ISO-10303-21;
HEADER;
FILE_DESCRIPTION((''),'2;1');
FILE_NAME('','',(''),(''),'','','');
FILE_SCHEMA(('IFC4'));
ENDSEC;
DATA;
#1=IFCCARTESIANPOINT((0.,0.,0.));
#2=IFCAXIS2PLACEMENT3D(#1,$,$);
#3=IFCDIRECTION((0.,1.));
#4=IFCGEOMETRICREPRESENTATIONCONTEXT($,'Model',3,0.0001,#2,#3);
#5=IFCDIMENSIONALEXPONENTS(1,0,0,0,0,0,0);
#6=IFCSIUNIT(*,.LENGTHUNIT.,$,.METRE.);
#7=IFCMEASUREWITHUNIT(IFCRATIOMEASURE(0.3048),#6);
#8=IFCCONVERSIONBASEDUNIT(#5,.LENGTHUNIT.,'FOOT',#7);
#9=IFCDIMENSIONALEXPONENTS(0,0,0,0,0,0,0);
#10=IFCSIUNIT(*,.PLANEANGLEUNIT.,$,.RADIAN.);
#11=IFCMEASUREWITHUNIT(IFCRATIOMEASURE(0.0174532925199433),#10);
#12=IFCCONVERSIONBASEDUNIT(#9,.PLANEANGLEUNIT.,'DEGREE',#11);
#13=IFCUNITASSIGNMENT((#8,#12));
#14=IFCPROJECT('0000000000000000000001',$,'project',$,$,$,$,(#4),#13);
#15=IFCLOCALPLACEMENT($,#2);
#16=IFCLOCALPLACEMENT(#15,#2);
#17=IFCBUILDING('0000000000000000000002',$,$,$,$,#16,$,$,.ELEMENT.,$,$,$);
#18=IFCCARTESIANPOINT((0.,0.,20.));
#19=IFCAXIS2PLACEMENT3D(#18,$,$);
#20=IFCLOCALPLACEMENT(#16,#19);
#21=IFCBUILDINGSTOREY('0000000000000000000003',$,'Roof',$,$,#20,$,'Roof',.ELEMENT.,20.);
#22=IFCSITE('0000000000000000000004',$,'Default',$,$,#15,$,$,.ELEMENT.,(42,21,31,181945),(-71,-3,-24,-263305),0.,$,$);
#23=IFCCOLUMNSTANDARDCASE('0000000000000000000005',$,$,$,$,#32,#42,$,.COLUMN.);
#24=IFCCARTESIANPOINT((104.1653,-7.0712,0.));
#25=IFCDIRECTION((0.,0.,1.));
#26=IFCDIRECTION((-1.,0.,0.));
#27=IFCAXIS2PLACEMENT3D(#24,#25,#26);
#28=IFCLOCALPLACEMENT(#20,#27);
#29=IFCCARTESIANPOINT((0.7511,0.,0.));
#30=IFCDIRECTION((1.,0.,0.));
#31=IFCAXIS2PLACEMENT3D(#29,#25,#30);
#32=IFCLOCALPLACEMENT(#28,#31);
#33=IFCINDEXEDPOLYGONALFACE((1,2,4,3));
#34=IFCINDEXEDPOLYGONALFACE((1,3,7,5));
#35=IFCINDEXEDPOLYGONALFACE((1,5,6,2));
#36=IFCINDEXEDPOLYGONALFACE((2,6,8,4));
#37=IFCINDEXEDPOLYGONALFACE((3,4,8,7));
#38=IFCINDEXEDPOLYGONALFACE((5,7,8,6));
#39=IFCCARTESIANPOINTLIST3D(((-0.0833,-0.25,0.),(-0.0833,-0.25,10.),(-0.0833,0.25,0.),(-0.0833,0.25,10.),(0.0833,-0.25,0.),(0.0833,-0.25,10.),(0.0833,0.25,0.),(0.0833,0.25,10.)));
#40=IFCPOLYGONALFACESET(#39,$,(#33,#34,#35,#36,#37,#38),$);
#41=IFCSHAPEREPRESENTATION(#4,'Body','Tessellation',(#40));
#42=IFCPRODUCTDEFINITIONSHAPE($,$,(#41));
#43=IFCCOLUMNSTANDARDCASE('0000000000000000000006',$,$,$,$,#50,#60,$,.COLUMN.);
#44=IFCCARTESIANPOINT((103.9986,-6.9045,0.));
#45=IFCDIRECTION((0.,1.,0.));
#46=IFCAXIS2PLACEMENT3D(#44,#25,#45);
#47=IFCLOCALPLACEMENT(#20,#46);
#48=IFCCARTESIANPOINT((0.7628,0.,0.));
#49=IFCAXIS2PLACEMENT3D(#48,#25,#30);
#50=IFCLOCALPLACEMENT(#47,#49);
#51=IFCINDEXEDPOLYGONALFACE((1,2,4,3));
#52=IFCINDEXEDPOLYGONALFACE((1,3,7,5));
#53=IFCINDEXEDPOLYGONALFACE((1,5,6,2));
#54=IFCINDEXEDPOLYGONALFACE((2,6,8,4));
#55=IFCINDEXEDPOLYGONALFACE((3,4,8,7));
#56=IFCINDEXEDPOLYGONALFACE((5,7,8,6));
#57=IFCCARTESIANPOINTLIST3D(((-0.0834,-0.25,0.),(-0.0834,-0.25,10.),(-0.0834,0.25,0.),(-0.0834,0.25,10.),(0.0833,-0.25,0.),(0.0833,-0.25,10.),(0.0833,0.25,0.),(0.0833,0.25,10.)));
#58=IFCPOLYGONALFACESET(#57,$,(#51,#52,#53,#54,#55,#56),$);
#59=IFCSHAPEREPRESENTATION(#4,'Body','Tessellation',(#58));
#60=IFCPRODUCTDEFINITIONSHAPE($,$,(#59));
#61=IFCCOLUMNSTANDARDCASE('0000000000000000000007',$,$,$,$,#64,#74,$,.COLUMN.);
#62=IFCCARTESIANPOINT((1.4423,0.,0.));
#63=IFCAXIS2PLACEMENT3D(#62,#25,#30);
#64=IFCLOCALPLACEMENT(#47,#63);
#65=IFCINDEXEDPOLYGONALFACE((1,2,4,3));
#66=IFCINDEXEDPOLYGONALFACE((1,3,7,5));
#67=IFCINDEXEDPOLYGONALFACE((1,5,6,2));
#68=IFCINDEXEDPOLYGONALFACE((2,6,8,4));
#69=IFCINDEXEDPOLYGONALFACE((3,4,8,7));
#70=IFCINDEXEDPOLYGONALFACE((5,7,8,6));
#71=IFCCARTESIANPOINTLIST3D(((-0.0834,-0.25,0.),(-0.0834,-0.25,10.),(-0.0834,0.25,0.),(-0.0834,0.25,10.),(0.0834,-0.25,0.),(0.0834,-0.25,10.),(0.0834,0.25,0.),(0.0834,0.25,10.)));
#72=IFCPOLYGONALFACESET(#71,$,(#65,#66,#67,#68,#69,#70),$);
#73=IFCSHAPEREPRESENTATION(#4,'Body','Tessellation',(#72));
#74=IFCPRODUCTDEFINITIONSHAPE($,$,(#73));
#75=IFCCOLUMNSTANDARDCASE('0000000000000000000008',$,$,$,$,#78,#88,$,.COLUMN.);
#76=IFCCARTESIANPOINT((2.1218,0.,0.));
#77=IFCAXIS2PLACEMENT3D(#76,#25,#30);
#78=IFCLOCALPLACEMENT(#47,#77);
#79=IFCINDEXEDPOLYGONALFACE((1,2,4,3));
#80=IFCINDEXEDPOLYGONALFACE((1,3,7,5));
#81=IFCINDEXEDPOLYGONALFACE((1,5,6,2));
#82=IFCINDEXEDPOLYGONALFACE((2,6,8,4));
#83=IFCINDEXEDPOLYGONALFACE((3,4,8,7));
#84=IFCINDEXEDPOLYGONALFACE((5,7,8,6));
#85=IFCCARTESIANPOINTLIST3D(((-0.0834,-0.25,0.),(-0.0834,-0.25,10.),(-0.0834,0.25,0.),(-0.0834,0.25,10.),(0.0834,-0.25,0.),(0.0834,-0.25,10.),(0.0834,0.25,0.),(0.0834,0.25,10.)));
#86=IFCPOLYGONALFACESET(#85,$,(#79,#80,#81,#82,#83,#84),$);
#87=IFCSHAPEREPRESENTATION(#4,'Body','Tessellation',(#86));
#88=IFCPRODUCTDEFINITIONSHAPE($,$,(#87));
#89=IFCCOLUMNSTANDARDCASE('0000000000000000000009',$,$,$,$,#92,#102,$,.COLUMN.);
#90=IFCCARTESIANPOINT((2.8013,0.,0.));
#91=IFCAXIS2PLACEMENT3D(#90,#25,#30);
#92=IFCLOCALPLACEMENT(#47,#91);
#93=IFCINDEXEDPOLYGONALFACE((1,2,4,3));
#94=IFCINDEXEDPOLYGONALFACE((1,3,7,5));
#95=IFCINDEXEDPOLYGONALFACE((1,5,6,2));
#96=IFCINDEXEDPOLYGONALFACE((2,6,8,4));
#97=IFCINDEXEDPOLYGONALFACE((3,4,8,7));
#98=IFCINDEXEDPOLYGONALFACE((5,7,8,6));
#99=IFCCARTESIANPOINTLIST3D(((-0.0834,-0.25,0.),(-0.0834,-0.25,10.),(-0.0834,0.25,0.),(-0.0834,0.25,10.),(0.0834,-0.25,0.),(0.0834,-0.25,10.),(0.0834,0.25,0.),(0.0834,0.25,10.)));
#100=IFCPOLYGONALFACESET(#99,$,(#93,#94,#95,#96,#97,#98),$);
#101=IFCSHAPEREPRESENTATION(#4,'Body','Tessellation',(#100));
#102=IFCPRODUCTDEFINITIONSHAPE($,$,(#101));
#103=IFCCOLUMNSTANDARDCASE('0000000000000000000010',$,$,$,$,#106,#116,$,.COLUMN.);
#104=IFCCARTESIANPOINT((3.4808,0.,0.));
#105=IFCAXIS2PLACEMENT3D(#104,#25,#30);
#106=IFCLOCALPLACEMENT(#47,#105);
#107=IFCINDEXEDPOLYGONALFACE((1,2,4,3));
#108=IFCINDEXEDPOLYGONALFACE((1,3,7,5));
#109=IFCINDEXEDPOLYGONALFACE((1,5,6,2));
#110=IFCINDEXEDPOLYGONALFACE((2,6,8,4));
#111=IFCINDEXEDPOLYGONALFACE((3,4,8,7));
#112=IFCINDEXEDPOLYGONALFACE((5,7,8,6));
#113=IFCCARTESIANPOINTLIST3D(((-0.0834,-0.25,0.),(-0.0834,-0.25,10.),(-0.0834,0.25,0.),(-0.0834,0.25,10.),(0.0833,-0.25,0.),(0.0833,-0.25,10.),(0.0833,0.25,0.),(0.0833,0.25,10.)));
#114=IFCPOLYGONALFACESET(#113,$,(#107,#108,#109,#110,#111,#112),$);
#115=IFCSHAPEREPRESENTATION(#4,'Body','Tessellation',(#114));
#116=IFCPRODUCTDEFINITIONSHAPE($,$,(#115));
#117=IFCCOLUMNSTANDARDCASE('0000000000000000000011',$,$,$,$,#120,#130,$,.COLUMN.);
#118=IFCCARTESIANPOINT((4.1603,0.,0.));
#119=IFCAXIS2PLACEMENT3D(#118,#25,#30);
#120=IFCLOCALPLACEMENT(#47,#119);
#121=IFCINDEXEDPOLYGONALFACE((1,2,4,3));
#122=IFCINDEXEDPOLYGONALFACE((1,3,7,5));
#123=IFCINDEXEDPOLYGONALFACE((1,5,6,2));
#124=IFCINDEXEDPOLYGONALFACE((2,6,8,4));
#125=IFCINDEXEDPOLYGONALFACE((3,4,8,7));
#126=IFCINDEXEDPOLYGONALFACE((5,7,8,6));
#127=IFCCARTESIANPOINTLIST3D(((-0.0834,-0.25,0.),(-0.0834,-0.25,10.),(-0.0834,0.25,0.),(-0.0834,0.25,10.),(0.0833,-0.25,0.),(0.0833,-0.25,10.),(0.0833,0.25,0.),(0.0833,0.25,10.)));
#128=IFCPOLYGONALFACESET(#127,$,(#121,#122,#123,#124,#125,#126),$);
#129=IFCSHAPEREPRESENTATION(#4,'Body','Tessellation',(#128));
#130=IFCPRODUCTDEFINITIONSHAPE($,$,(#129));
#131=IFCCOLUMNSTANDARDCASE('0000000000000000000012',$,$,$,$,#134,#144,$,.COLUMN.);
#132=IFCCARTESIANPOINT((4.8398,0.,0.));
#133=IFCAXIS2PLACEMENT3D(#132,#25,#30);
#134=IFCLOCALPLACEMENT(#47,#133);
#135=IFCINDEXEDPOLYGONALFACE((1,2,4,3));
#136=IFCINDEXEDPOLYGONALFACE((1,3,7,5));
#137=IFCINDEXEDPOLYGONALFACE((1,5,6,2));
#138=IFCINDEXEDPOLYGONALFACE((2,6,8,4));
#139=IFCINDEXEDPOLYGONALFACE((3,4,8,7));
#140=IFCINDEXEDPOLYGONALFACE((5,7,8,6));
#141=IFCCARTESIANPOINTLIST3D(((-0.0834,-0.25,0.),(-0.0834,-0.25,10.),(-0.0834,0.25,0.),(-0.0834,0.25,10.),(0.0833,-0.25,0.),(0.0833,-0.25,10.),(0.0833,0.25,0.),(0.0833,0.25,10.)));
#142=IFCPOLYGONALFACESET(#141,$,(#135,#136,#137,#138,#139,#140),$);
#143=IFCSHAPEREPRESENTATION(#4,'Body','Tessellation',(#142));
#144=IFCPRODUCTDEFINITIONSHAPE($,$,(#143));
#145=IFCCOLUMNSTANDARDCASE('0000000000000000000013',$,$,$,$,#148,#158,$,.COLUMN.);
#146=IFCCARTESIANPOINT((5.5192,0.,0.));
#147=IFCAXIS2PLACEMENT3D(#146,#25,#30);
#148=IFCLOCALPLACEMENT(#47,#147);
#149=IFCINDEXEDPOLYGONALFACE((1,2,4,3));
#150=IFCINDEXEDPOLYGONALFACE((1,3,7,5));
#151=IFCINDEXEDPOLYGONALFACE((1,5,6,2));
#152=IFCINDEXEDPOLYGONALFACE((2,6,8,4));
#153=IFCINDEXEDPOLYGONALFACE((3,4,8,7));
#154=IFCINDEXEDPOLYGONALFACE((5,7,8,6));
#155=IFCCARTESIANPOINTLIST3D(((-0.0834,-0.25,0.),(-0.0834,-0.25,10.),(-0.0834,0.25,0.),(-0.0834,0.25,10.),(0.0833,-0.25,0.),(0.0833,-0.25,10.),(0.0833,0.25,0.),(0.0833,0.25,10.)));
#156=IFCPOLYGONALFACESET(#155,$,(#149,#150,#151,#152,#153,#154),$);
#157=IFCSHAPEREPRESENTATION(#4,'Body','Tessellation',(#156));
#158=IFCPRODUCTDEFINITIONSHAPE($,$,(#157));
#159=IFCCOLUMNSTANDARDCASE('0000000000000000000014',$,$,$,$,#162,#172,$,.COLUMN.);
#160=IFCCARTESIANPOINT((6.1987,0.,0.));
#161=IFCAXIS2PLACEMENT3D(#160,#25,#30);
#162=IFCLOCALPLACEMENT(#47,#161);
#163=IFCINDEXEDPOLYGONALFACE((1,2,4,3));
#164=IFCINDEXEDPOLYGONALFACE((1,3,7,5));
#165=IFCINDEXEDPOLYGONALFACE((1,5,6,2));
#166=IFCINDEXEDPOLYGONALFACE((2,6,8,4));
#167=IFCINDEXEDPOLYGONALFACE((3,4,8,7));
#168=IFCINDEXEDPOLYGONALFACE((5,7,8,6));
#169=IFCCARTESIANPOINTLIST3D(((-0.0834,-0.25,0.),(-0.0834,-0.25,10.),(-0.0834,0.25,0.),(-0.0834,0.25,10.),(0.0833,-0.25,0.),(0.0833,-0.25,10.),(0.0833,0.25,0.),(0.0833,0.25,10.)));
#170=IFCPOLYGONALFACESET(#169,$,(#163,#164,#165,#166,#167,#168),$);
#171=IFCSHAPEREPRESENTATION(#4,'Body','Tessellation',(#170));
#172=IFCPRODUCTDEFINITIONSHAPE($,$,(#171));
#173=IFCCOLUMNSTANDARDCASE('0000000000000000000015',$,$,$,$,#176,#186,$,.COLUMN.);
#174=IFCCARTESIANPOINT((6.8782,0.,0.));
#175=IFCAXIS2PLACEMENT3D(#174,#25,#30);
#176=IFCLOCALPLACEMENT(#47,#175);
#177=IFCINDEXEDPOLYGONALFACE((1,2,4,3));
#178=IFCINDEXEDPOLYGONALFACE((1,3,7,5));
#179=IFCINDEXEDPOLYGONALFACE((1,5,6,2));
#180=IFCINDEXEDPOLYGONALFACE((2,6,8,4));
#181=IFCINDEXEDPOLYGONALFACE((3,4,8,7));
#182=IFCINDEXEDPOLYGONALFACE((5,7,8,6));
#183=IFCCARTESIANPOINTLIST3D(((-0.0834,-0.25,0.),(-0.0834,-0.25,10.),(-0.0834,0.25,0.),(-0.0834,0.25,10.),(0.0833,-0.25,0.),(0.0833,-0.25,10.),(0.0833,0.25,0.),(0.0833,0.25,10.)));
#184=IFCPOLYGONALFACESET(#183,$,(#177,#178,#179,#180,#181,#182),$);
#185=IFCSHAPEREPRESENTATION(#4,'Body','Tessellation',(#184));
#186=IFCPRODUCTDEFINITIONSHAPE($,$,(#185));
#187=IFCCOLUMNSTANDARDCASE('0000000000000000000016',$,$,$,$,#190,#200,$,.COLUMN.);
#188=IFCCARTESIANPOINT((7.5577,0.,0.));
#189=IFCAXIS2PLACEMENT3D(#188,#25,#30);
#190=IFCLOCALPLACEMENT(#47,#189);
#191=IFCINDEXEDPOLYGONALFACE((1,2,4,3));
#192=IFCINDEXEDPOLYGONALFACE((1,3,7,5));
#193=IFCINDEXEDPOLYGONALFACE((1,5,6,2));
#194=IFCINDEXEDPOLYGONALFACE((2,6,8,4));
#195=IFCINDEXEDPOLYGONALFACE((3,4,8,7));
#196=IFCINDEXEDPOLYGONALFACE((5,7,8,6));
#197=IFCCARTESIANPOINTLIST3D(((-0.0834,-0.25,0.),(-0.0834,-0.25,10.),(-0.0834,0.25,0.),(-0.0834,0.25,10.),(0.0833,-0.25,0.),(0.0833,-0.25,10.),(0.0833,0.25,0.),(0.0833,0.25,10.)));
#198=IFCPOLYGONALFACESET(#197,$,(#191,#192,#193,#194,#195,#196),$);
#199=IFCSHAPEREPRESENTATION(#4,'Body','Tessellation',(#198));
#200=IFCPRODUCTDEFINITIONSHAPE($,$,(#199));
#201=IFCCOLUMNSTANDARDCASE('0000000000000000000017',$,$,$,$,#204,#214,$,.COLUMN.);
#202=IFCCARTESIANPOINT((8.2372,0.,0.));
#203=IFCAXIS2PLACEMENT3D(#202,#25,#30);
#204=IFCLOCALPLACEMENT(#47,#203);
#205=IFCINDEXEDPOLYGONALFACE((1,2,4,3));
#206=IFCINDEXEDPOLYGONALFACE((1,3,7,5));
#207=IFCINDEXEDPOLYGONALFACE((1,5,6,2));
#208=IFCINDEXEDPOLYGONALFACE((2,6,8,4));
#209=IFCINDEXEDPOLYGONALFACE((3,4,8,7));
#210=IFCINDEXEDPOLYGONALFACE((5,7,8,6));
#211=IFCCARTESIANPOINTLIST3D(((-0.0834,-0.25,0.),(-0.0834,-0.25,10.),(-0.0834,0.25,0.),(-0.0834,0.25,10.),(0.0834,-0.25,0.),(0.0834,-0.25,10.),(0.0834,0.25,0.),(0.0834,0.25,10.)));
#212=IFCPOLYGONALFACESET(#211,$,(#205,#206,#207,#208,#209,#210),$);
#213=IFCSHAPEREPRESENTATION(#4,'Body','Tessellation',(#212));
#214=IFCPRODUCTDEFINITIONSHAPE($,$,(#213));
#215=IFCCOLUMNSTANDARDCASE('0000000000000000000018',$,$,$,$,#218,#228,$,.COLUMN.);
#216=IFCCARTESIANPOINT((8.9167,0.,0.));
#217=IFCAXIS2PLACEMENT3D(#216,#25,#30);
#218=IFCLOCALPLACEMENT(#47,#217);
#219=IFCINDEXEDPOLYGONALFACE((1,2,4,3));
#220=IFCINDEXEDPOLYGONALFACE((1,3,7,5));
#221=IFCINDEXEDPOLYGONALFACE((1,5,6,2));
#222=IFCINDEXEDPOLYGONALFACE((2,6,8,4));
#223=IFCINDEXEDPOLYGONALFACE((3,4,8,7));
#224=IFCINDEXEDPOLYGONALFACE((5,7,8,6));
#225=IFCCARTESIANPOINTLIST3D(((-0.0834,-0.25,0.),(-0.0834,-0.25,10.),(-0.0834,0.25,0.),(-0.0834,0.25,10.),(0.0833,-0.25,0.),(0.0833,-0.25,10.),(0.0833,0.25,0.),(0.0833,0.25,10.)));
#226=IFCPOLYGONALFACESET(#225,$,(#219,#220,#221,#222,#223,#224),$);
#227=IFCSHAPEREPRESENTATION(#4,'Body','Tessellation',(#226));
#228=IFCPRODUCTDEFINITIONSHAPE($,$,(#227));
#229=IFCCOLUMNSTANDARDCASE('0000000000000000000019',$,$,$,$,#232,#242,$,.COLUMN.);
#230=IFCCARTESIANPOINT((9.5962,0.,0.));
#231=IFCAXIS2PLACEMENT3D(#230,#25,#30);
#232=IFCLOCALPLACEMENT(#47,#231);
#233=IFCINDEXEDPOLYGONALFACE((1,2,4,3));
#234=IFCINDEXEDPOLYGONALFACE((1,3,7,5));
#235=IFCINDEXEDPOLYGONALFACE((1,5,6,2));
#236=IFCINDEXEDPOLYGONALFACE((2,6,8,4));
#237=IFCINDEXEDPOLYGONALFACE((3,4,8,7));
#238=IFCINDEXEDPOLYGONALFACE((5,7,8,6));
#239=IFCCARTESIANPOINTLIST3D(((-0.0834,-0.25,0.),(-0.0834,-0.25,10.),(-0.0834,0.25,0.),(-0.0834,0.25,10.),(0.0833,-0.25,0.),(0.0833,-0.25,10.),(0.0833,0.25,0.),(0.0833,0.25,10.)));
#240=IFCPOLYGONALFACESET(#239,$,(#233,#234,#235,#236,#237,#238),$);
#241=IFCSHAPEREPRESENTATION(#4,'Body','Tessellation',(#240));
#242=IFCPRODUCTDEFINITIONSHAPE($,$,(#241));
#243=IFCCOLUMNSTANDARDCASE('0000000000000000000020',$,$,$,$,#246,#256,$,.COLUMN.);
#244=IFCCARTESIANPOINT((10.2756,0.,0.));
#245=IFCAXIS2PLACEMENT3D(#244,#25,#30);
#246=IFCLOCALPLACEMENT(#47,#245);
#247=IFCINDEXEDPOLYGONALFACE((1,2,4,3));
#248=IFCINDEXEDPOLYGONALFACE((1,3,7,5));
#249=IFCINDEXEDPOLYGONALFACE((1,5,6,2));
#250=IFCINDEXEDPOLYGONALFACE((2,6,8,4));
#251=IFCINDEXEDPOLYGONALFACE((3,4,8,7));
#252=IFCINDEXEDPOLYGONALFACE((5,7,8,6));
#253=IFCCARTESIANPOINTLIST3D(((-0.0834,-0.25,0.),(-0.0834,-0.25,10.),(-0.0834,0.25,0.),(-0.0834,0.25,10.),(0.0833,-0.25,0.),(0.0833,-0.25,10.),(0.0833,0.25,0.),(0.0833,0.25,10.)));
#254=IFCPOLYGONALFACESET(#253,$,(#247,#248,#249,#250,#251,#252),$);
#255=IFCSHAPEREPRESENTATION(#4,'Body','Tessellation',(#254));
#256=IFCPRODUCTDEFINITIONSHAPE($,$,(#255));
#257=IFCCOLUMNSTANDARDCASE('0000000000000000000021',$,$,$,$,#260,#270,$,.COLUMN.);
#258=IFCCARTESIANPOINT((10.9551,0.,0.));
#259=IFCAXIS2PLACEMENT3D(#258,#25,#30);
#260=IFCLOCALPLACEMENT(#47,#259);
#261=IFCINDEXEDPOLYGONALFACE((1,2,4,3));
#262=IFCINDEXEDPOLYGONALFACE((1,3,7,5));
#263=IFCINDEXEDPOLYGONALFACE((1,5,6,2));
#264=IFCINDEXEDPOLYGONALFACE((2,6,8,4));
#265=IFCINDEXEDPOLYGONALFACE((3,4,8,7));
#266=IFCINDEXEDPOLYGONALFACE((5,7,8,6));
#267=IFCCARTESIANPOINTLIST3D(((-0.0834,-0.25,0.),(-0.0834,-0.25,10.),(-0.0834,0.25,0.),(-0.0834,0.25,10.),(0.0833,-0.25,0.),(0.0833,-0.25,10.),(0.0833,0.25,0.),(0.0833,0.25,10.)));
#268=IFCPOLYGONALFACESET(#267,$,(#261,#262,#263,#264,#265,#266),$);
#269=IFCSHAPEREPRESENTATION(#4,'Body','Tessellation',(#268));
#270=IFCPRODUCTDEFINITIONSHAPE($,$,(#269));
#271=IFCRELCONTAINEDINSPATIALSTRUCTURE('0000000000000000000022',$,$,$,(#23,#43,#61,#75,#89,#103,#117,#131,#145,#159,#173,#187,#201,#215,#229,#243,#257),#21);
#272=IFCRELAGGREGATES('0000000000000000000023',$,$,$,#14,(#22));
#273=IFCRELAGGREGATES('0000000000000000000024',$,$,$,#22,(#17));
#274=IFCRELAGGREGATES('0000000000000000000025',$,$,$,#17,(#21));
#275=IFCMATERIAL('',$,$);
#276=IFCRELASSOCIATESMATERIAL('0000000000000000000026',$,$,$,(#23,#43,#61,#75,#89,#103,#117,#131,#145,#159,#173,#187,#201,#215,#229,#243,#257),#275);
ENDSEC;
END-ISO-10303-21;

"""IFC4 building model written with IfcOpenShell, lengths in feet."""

from ifc_helpers import new_model, entity, si_unit, converted_unit, direction, frame, origin, place, context, project, spatial, rectangle, extrude, material, element, save


model = new_model("IFC4")

# Units and contexts
model_context = context("Model", 3, precision=0.0001, world=origin(), true_north=direction((0.0, 1.0)))
ifc_project = project(units=[converted_unit("LENGTHUNIT", "FOOT", entity("IfcRatioMeasure", 0.3048), si_unit("LENGTHUNIT", "METRE"), dimensions=[1, 0, 0, 0, 0, 0, 0]), converted_unit("PLANEANGLEUNIT", "DEGREE", entity("IfcRatioMeasure", 0.0174532925199433), si_unit("PLANEANGLEUNIT", "RADIAN"), dimensions=[0, 0, 0, 0, 0, 0, 0])], contexts=[model_context])

# Site, building, storey
site_placement = place(None, origin())
site = spatial("IfcSite", under=ifc_project, at=site_placement, Name="Default", CompositionType="ELEMENT", RefLatitude=(42, 21, 31, 181945), RefLongitude=(-71, -3, -24, -263305), RefElevation=0.0)
building_placement = place(site_placement, origin())
building = spatial("IfcBuilding", under=site, at=building_placement, CompositionType="ELEMENT")
storey_placement = place(building_placement, frame((0.0, 0.0, 20.0)))
storey = spatial("IfcBuildingStorey", under=building, at=storey_placement, Name="Roof", LongName="Roof", CompositionType="ELEMENT", Elevation=20.0)

# Columns
ifc_material_1 = material(Name="")
wall_1_placement = place(storey_placement, frame((104.1653, -7.0712, 0.0), z_axis=(0.0, 0.0, 1.0), x_axis=(-1.0, 0.0, 0.0)))
for number, where, z_axis, x_axis in (
    (1, (0.7511, 0.0, 0.0), (0.0, 0.0, 1.0), (1.0, 0.0, 0.0)),
):
    element("IfcColumnStandardCase", number, at=place(wall_1_placement, frame(where, z_axis=z_axis, x_axis=x_axis)), inside=storey, material=ifc_material_1, PredefinedType="COLUMN", context=model_context, shape_type="SweptSolid", body=[
        extrude(rectangle(XDim=0.1667, YDim=0.5), origin(), (0.0, 0.0, 1.0), 10.0),
    ])
wall_2_placement = place(storey_placement, frame((103.9986, -6.9045, 0.0), z_axis=(0.0, 0.0, 1.0), x_axis=(0.0, 1.0, 0.0)))
for number, where, z_axis, x_axis in (
    (2, (0.7628, 0.0, 0.0), (0.0, 0.0, 1.0), (1.0, 0.0, 0.0)),
    (3, (1.4423, 0.0, 0.0), (0.0, 0.0, 1.0), (1.0, 0.0, 0.0)),
    (4, (2.1218, 0.0, 0.0), (0.0, 0.0, 1.0), (1.0, 0.0, 0.0)),
    (5, (2.8013, 0.0, 0.0), (0.0, 0.0, 1.0), (1.0, 0.0, 0.0)),
    (6, (3.4808, 0.0, 0.0), (0.0, 0.0, 1.0), (1.0, 0.0, 0.0)),
    (7, (4.1603, 0.0, 0.0), (0.0, 0.0, 1.0), (1.0, 0.0, 0.0)),
    (8, (4.8398, 0.0, 0.0), (0.0, 0.0, 1.0), (1.0, 0.0, 0.0)),
    (9, (5.5192, 0.0, 0.0), (0.0, 0.0, 1.0), (1.0, 0.0, 0.0)),
    (10, (6.1987, 0.0, 0.0), (0.0, 0.0, 1.0), (1.0, 0.0, 0.0)),
    (11, (6.8782, 0.0, 0.0), (0.0, 0.0, 1.0), (1.0, 0.0, 0.0)),
    (12, (7.5577, 0.0, 0.0), (0.0, 0.0, 1.0), (1.0, 0.0, 0.0)),
    (13, (8.2372, 0.0, 0.0), (0.0, 0.0, 1.0), (1.0, 0.0, 0.0)),
    (14, (8.9167, 0.0, 0.0), (0.0, 0.0, 1.0), (1.0, 0.0, 0.0)),
    (15, (9.5962, 0.0, 0.0), (0.0, 0.0, 1.0), (1.0, 0.0, 0.0)),
    (16, (10.2756, 0.0, 0.0), (0.0, 0.0, 1.0), (1.0, 0.0, 0.0)),
    (17, (10.9551, 0.0, 0.0), (0.0, 0.0, 1.0), (1.0, 0.0, 0.0)),
):
    element("IfcColumnStandardCase", number, at=place(wall_2_placement, frame(where, z_axis=z_axis, x_axis=x_axis)), inside=storey, material=ifc_material_1, PredefinedType="COLUMN", context=model_context, shape_type="SweptSolid", body=[
        extrude(rectangle(XDim=0.1667, YDim=0.5), origin(), (0.0, 0.0, 1.0), 10.0),
    ])

save(model, "model.ifc")
